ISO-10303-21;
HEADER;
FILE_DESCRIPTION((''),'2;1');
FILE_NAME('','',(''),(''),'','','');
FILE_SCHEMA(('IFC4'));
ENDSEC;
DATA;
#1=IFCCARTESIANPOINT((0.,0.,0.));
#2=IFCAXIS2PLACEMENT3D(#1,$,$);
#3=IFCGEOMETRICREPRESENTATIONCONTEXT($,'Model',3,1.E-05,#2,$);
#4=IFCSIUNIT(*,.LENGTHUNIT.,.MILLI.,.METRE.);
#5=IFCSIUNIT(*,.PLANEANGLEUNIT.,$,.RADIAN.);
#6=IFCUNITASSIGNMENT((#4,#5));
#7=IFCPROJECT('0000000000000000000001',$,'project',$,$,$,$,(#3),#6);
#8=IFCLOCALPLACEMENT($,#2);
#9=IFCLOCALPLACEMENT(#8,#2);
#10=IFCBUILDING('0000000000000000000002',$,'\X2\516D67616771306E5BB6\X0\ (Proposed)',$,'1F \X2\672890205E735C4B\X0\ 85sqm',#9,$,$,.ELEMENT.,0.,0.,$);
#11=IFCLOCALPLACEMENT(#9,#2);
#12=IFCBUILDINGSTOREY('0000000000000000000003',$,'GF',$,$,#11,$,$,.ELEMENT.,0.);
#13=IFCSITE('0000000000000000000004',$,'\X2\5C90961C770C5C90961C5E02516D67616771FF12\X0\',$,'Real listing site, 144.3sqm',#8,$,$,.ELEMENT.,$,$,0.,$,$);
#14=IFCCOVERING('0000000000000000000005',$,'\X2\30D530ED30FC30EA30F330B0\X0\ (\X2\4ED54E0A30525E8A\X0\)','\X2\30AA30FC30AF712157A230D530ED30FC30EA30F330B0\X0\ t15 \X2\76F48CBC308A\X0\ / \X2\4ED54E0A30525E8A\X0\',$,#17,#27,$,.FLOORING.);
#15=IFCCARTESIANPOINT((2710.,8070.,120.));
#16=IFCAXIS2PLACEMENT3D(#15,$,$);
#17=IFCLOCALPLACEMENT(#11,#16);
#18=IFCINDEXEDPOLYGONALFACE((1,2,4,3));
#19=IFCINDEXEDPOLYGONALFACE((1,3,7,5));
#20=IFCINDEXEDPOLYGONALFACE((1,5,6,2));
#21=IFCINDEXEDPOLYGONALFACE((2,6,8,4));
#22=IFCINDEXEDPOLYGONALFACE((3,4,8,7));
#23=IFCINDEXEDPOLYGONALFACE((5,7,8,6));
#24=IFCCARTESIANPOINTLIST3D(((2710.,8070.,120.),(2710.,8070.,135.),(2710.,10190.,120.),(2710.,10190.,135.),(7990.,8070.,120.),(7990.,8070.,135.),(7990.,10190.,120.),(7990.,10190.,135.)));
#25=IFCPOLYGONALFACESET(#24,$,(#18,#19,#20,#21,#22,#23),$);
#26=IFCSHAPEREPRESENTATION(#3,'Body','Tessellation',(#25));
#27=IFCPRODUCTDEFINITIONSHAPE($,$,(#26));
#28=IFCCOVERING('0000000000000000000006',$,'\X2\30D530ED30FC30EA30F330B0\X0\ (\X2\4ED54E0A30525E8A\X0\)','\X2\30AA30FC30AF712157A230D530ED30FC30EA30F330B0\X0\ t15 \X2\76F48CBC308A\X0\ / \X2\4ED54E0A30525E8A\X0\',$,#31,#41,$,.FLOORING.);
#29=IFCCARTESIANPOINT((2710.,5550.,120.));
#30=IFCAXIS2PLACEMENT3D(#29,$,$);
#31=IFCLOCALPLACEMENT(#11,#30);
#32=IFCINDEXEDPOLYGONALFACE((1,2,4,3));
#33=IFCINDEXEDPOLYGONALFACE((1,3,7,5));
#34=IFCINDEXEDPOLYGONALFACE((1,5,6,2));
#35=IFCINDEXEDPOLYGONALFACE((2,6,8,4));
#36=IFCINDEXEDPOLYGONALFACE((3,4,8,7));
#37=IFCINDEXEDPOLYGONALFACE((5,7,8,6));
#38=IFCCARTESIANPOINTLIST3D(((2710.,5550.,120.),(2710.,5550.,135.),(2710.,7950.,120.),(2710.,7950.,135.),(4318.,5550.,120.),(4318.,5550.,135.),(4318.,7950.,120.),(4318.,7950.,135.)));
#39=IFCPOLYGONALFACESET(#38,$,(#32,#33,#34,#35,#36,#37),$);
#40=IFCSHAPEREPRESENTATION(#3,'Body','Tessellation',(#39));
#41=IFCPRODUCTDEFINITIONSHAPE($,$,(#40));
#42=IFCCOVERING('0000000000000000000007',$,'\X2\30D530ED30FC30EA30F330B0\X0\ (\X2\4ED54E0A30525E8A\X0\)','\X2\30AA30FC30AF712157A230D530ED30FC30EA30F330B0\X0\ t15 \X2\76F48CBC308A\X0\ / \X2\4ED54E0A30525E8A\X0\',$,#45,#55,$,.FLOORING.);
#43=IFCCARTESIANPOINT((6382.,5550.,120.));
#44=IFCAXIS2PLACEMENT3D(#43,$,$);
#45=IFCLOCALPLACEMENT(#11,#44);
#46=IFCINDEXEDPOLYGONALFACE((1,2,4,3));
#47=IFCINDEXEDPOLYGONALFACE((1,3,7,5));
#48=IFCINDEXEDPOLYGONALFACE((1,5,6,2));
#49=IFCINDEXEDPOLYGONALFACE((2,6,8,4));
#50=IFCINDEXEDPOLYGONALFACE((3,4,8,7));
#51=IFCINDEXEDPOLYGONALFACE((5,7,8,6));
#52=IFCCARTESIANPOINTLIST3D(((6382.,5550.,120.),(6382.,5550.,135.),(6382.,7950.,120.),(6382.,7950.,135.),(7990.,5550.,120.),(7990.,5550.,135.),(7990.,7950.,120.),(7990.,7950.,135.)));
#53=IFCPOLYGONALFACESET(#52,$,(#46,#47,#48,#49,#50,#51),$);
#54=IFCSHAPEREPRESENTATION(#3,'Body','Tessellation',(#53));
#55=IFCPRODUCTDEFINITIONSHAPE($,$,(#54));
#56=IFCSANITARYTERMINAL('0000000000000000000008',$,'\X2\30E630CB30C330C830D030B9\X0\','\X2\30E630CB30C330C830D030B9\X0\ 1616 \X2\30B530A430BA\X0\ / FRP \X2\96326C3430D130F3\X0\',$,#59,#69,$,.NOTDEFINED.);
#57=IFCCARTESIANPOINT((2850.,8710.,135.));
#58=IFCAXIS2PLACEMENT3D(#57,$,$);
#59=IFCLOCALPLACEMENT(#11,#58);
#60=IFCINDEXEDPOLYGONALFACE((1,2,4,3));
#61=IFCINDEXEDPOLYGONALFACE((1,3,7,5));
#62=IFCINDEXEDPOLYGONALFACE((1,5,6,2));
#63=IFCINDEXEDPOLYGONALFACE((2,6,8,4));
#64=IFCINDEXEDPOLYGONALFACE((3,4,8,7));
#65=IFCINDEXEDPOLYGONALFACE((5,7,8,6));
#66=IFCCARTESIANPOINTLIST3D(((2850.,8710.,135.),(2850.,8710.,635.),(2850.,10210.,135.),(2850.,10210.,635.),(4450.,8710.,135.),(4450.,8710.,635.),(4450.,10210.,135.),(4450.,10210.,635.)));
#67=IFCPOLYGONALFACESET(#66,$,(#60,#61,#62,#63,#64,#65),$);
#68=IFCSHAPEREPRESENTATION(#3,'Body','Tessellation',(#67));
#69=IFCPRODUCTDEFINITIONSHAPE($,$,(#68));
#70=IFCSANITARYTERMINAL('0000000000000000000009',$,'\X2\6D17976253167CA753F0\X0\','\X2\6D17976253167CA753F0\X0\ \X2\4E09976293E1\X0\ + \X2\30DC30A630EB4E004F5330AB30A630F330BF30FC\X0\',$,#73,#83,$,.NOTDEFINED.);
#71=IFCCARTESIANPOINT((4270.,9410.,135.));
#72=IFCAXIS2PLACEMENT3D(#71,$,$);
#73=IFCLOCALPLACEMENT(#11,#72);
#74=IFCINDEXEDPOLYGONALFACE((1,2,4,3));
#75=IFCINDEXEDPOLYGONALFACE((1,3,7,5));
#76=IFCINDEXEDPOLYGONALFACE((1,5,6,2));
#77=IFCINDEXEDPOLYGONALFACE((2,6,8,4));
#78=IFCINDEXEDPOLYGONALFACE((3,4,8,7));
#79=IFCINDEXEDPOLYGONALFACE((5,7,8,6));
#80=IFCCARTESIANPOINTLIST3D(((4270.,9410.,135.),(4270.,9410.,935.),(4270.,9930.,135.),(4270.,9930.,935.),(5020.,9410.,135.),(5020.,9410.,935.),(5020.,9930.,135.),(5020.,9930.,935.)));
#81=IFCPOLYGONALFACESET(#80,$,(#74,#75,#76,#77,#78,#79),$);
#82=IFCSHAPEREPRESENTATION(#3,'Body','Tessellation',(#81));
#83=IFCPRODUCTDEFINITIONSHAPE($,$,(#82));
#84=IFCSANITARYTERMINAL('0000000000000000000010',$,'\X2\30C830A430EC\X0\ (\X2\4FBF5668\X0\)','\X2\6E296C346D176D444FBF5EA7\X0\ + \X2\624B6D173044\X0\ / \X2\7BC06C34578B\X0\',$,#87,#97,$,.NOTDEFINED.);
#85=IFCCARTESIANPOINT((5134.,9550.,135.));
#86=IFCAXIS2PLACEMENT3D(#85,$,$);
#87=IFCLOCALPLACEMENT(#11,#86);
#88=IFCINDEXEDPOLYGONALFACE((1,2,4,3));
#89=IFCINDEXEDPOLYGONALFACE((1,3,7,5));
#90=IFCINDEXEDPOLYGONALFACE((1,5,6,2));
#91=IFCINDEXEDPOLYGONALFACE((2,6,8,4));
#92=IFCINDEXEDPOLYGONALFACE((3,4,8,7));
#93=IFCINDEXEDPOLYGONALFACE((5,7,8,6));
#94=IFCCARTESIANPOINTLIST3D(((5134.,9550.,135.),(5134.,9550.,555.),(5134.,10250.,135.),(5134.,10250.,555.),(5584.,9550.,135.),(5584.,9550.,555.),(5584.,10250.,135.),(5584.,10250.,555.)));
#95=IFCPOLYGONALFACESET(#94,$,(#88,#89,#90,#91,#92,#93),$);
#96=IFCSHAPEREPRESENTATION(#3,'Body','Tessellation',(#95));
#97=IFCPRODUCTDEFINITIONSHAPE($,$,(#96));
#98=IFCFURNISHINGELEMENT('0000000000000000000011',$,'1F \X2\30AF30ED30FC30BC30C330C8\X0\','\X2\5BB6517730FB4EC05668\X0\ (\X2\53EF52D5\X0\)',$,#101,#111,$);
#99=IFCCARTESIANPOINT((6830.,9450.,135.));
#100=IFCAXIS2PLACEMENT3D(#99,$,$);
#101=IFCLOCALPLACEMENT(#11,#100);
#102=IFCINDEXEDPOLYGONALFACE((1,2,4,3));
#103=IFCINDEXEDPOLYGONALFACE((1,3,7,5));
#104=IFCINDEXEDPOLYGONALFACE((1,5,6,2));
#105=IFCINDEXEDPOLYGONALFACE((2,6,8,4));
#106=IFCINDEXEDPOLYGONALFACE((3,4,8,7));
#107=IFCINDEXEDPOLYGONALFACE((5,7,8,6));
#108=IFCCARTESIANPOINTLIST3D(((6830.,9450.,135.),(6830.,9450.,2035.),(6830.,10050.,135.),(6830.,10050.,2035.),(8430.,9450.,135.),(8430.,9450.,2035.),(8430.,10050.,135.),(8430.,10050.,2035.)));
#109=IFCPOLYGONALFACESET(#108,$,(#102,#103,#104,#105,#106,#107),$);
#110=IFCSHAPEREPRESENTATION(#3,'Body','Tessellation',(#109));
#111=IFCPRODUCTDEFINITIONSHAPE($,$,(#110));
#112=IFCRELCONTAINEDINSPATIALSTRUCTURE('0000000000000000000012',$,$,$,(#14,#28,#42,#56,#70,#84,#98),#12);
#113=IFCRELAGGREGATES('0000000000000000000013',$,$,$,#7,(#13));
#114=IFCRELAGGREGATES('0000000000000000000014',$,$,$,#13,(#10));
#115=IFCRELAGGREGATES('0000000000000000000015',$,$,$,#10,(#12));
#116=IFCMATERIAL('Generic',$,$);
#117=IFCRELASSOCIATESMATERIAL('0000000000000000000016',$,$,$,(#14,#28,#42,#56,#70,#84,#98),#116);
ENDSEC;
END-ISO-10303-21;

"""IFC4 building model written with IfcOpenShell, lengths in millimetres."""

from ifc_helpers import new_model, si_unit, frame, frame_2d, origin, place, context, project, spatial, rectangle, extrude, material, element, save


model = new_model("IFC4")

# Units and contexts
model_context = context("Model", 3, precision=1e-05, world=origin())
ifc_project = project(units=[si_unit("LENGTHUNIT", "METRE", prefix="MILLI"), si_unit("PLANEANGLEUNIT", "RADIAN")], contexts=[model_context])

# Site, building, storey
site_placement = place(None, origin())
site = spatial("IfcSite", under=ifc_project, at=site_placement, Name="岐阜県岐阜市六条東２", ObjectType="Real listing site, 144.3sqm", CompositionType="ELEMENT", RefElevation=0.0)
building_placement = place(site_placement, origin())
building = spatial("IfcBuilding", under=site, at=building_placement, Name="六条東の家 (Proposed)", ObjectType="1F 木造平屋 85sqm", CompositionType="ELEMENT", ElevationOfRefHeight=0.0, ElevationOfTerrain=0.0)
storey_placement = place(building_placement, origin())
storey = spatial("IfcBuildingStorey", under=building, at=storey_placement, Name="GF", CompositionType="ELEMENT", Elevation=0.0)

# Coverings
ifc_material_1 = material(Name="Generic")
covering_1_placement = place(storey_placement, frame((2710.0, 8070.0, 120.0)))
element("IfcCovering", 1, at=covering_1_placement, inside=storey, material=ifc_material_1, Name="フローリング (仕上げ床)", Description="オーク無垢フローリング t15 直貼り / 仕上げ床", PredefinedType="FLOORING", context=model_context, shape_type="SweptSolid", body=[
    extrude(rectangle(XDim=5280.0, YDim=2120.0, at=frame_2d((2640.0, 1060.0))), frame((2710.0, 8070.0, 120.0)), (0.0, 0.0, 1.0), 15.0),
])
covering_2_placement = place(storey_placement, frame((2710.0, 5550.0, 120.0)))
element("IfcCovering", 2, at=covering_2_placement, inside=storey, material=ifc_material_1, Name="フローリング (仕上げ床)", Description="オーク無垢フローリング t15 直貼り / 仕上げ床", PredefinedType="FLOORING", context=model_context, shape_type="SweptSolid", body=[
    extrude(rectangle(XDim=1608.0, YDim=2400.0, at=frame_2d((804.0, 1200.0))), frame((2710.0, 5550.0, 120.0)), (0.0, 0.0, 1.0), 15.0),
])
covering_3_placement = place(storey_placement, frame((6382.0, 5550.0, 120.0)))
element("IfcCovering", 3, at=covering_3_placement, inside=storey, material=ifc_material_1, Name="フローリング (仕上げ床)", Description="オーク無垢フローリング t15 直貼り / 仕上げ床", PredefinedType="FLOORING", context=model_context, shape_type="SweptSolid", body=[
    extrude(rectangle(XDim=1608.0, YDim=2400.0, at=frame_2d((804.0, 1200.0))), frame((6382.0, 5550.0, 120.0)), (0.0, 0.0, 1.0), 15.0),
])

# Sanitary terminals
sanitary_terminal_1_placement = place(storey_placement, frame((2850.0, 8710.0, 135.0)))
element("IfcSanitaryTerminal", 4, at=sanitary_terminal_1_placement, inside=storey, material=ifc_material_1, Name="ユニットバス", Description="ユニットバス 1616 サイズ / FRP 防水パン", PredefinedType="NOTDEFINED", context=model_context, shape_type="SweptSolid", body=[
    extrude(rectangle(XDim=1600.0, YDim=1500.0, at=frame_2d((800.0, 750.0))), frame((2850.0, 8710.0, 135.0)), (0.0, 0.0, 1.0), 500.0),
])
sanitary_terminal_2_placement = place(storey_placement, frame((4270.0, 9410.0, 135.0)))
element("IfcSanitaryTerminal", 5, at=sanitary_terminal_2_placement, inside=storey, material=ifc_material_1, Name="洗面化粧台", Description="洗面化粧台 三面鏡 + ボウル一体カウンター", PredefinedType="NOTDEFINED", context=model_context, shape_type="SweptSolid", body=[
    extrude(rectangle(XDim=750.0, YDim=520.0, at=frame_2d((375.0, 260.0))), frame((4270.0, 9410.0, 135.0)), (0.0, 0.0, 1.0), 800.0),
])
sanitary_terminal_3_placement = place(storey_placement, frame((5134.0, 9550.0, 135.0)))
element("IfcSanitaryTerminal", 6, at=sanitary_terminal_3_placement, inside=storey, material=ifc_material_1, Name="トイレ (便器)", Description="温水洗浄便座 + 手洗い / 節水型", PredefinedType="NOTDEFINED", context=model_context, shape_type="SweptSolid", body=[
    extrude(rectangle(XDim=450.0, YDim=700.0, at=frame_2d((225.0, 350.0))), frame((5134.0, 9550.0, 135.0)), (0.0, 0.0, 1.0), 420.0),
])

# Furnishing element
furnishing_placement = place(storey_placement, frame((6830.0, 9450.0, 135.0)))
element("IfcFurnishingElement", 7, at=furnishing_placement, inside=storey, material=ifc_material_1, Name="1F クローゼット", Description="家具・什器 (可動)", context=model_context, shape_type="SweptSolid", body=[
    extrude(rectangle(XDim=1600.0, YDim=600.0, at=frame_2d((800.0, 300.0))), frame((6830.0, 9450.0, 135.0)), (0.0, 0.0, 1.0), 1900.0),
])

save(model, "model.ifc")
